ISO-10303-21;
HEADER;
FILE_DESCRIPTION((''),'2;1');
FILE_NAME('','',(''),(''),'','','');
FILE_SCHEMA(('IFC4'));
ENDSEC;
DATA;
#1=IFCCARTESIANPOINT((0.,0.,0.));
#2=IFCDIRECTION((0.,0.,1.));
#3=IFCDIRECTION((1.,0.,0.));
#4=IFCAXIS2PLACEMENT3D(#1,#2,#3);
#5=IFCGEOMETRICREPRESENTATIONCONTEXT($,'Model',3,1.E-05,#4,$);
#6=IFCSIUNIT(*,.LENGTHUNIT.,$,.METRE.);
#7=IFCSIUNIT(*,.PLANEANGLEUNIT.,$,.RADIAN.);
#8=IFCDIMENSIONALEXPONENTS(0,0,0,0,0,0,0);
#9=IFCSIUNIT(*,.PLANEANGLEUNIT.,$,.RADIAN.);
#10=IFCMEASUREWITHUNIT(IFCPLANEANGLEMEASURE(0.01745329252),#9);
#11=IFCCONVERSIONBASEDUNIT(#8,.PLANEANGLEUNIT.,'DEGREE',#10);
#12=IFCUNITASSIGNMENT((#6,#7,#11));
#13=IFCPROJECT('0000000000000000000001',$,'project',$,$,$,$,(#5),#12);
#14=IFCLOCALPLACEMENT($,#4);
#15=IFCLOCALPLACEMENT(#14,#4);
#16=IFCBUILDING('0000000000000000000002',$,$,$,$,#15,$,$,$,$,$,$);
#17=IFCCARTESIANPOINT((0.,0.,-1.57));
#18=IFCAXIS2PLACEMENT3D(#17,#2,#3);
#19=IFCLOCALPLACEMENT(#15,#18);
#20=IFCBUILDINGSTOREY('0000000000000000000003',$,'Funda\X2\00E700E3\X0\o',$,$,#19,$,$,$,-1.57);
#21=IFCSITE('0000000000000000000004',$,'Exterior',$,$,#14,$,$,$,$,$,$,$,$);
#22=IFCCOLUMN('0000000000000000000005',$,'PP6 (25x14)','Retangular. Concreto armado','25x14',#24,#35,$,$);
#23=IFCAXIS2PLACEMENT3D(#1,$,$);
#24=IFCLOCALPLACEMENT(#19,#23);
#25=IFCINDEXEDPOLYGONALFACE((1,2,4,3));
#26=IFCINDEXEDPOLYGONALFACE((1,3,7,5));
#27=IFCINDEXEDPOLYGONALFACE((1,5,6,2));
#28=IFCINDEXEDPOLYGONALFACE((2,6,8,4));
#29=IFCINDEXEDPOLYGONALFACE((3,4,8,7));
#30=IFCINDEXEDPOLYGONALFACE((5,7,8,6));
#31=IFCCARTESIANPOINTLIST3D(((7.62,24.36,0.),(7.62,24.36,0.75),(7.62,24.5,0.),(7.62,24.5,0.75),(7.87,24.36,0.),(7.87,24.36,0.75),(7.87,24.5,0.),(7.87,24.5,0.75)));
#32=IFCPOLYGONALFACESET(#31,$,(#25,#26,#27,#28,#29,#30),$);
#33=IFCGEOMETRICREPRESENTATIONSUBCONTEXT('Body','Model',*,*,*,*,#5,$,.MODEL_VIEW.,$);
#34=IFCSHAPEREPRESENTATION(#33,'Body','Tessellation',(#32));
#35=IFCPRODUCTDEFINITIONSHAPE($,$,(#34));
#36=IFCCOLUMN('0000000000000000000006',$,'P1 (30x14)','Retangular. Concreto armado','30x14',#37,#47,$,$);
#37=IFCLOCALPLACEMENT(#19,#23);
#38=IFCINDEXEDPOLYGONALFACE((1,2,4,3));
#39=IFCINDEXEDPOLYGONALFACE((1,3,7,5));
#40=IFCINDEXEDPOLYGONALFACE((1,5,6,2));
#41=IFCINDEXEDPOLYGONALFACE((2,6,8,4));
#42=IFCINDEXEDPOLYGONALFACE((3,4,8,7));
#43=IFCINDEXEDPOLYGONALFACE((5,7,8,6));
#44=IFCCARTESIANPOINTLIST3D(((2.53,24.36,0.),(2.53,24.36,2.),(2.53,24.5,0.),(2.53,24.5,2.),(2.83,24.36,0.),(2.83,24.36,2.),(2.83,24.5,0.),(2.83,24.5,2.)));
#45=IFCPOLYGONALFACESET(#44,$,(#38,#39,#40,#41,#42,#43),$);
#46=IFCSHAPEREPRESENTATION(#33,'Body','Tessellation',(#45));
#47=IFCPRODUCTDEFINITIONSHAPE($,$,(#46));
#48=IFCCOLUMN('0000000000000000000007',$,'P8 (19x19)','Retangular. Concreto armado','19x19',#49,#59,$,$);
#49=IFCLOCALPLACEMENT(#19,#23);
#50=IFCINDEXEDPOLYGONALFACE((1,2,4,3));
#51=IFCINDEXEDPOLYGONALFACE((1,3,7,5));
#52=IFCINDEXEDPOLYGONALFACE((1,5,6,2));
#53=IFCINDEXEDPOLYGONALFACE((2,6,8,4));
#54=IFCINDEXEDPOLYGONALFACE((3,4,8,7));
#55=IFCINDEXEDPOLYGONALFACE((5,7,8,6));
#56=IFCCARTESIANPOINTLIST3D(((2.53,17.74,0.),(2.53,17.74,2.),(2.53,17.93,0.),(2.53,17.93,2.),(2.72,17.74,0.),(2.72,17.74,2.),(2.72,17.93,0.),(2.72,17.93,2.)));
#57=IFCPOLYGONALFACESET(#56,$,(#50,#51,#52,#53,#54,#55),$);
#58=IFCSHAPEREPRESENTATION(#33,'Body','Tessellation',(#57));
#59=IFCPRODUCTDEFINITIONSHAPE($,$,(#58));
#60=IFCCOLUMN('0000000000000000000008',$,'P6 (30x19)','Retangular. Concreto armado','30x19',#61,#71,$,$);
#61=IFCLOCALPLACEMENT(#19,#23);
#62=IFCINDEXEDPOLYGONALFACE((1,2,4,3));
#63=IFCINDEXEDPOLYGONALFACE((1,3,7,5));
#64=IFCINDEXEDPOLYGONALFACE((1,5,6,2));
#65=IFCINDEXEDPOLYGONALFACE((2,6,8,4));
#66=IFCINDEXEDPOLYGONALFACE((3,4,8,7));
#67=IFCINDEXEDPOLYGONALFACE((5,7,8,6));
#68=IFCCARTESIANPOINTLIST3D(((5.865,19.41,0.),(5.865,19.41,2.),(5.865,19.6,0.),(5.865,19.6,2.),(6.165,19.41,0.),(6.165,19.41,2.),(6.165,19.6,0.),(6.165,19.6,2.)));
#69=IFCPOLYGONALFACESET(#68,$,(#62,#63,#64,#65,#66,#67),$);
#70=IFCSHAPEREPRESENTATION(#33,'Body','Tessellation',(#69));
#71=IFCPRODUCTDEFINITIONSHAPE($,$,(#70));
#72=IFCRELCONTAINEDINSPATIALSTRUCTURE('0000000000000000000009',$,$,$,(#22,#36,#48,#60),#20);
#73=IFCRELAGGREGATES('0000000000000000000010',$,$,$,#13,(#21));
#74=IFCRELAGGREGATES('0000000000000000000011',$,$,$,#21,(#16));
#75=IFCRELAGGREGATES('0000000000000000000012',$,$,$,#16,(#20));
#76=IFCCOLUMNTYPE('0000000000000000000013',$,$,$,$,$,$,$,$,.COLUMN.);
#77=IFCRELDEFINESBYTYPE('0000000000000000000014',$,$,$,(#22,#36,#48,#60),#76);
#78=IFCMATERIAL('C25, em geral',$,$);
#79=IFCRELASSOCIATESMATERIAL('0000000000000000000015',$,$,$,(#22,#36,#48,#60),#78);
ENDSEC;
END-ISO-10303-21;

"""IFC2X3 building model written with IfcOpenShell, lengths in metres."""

from ifc_helpers import new_model, entity, si_unit, converted_unit, frame, frame_2d, origin_with_axes, place, context, subcontext, project, spatial, rectangle, extrude, material, type_object, element, save


model = new_model("IFC2X3")

# Units and contexts
model_context = context("Model", 3, precision=1e-05, world=origin_with_axes())
body_context = subcontext(model_context, "Body", "Model", "MODEL_VIEW")
ifc_project = project(units=[si_unit("LENGTHUNIT", "METRE"), si_unit("PLANEANGLEUNIT", "RADIAN"), converted_unit("PLANEANGLEUNIT", "DEGREE", entity("IfcPlaneAngleMeasure", 0.01745329252), si_unit("PLANEANGLEUNIT", "RADIAN"), dimensions=[0, 0, 0, 0, 0, 0, 0])], contexts=[model_context])

# Site, building, storey
site_placement = place(None, origin_with_axes())
site = spatial("IfcSite", under=ifc_project, at=site_placement, Name="Exterior")
building_placement = place(site_placement, origin_with_axes())
building = spatial("IfcBuilding", under=site, at=building_placement)
storey_placement = place(building_placement, frame((0.0, 0.0, -1.57), z_axis=(0.0, 0.0, 1.0), x_axis=(1.0, 0.0, 0.0)))
storey = spatial("IfcBuildingStorey", under=building, at=storey_placement, Name="Fundação", Elevation=-1.57)

# Columns
ifc_material_1 = material(Name="C25, em geral")
column_type = type_object("IfcColumnType", PredefinedType="COLUMN")
column_1_placement = place(storey_placement, frame((7.87, 24.5, 0.0), z_axis=(0.0, 0.0, 1.0), x_axis=(1.0, 0.0, 0.0)))
element("IfcColumn", 1, at=column_1_placement, inside=storey, type_object=column_type, material=ifc_material_1, Name="PP6 (25x14)", Description="Retangular. Concreto armado", ObjectType="25x14", context=body_context, shape_type="SweptSolid", body=[
    extrude(rectangle(XDim=0.25, YDim=0.14, at=frame_2d((-0.125, -0.07), x_axis=(1.0, 0.0))), origin_with_axes(), (0.0, 0.0, 1.0), 0.75),
])
column_2_placement = place(storey_placement, frame((2.53, 24.36, 0.0), z_axis=(0.0, 0.0, 1.0), x_axis=(1.0, 0.0, 0.0)))
element("IfcColumn", 2, at=column_2_placement, inside=storey, type_object=column_type, material=ifc_material_1, Name="P1 (30x14)", Description="Retangular. Concreto armado", ObjectType="30x14", context=body_context, shape_type="SweptSolid", body=[
    extrude(rectangle(XDim=0.3, YDim=0.14, at=frame_2d((0.15, 0.07), x_axis=(1.0, 0.0))), origin_with_axes(), (0.0, 0.0, 1.0), 2.0),
])
column_3_placement = place(storey_placement, frame((2.53, 17.835, 0.0), z_axis=(0.0, 0.0, 1.0), x_axis=(1.0, 0.0, 0.0)))
element("IfcColumn", 3, at=column_3_placement, inside=storey, type_object=column_type, material=ifc_material_1, Name="P8 (19x19)", Description="Retangular. Concreto armado", ObjectType="19x19", context=body_context, shape_type="SweptSolid", body=[
    extrude(rectangle(XDim=0.19, YDim=0.19, at=frame_2d((0.095, 0.0), x_axis=(1.0, 0.0))), origin_with_axes(), (0.0, 0.0, 1.0), 2.0),
])
column_4_placement = place(storey_placement, frame((6.015, 19.6, 0.0), z_axis=(0.0, 0.0, 1.0), x_axis=(1.0, 0.0, 0.0)))
element("IfcColumn", 4, at=column_4_placement, inside=storey, type_object=column_type, material=ifc_material_1, Name="P6 (30x19)", Description="Retangular. Concreto armado", ObjectType="30x19", context=body_context, shape_type="SweptSolid", body=[
    extrude(rectangle(XDim=0.3, YDim=0.19, at=frame_2d((0.0, -0.095), x_axis=(1.0, 0.0))), origin_with_axes(), (0.0, 0.0, 1.0), 2.0),
])

save(model, "model.ifc")
